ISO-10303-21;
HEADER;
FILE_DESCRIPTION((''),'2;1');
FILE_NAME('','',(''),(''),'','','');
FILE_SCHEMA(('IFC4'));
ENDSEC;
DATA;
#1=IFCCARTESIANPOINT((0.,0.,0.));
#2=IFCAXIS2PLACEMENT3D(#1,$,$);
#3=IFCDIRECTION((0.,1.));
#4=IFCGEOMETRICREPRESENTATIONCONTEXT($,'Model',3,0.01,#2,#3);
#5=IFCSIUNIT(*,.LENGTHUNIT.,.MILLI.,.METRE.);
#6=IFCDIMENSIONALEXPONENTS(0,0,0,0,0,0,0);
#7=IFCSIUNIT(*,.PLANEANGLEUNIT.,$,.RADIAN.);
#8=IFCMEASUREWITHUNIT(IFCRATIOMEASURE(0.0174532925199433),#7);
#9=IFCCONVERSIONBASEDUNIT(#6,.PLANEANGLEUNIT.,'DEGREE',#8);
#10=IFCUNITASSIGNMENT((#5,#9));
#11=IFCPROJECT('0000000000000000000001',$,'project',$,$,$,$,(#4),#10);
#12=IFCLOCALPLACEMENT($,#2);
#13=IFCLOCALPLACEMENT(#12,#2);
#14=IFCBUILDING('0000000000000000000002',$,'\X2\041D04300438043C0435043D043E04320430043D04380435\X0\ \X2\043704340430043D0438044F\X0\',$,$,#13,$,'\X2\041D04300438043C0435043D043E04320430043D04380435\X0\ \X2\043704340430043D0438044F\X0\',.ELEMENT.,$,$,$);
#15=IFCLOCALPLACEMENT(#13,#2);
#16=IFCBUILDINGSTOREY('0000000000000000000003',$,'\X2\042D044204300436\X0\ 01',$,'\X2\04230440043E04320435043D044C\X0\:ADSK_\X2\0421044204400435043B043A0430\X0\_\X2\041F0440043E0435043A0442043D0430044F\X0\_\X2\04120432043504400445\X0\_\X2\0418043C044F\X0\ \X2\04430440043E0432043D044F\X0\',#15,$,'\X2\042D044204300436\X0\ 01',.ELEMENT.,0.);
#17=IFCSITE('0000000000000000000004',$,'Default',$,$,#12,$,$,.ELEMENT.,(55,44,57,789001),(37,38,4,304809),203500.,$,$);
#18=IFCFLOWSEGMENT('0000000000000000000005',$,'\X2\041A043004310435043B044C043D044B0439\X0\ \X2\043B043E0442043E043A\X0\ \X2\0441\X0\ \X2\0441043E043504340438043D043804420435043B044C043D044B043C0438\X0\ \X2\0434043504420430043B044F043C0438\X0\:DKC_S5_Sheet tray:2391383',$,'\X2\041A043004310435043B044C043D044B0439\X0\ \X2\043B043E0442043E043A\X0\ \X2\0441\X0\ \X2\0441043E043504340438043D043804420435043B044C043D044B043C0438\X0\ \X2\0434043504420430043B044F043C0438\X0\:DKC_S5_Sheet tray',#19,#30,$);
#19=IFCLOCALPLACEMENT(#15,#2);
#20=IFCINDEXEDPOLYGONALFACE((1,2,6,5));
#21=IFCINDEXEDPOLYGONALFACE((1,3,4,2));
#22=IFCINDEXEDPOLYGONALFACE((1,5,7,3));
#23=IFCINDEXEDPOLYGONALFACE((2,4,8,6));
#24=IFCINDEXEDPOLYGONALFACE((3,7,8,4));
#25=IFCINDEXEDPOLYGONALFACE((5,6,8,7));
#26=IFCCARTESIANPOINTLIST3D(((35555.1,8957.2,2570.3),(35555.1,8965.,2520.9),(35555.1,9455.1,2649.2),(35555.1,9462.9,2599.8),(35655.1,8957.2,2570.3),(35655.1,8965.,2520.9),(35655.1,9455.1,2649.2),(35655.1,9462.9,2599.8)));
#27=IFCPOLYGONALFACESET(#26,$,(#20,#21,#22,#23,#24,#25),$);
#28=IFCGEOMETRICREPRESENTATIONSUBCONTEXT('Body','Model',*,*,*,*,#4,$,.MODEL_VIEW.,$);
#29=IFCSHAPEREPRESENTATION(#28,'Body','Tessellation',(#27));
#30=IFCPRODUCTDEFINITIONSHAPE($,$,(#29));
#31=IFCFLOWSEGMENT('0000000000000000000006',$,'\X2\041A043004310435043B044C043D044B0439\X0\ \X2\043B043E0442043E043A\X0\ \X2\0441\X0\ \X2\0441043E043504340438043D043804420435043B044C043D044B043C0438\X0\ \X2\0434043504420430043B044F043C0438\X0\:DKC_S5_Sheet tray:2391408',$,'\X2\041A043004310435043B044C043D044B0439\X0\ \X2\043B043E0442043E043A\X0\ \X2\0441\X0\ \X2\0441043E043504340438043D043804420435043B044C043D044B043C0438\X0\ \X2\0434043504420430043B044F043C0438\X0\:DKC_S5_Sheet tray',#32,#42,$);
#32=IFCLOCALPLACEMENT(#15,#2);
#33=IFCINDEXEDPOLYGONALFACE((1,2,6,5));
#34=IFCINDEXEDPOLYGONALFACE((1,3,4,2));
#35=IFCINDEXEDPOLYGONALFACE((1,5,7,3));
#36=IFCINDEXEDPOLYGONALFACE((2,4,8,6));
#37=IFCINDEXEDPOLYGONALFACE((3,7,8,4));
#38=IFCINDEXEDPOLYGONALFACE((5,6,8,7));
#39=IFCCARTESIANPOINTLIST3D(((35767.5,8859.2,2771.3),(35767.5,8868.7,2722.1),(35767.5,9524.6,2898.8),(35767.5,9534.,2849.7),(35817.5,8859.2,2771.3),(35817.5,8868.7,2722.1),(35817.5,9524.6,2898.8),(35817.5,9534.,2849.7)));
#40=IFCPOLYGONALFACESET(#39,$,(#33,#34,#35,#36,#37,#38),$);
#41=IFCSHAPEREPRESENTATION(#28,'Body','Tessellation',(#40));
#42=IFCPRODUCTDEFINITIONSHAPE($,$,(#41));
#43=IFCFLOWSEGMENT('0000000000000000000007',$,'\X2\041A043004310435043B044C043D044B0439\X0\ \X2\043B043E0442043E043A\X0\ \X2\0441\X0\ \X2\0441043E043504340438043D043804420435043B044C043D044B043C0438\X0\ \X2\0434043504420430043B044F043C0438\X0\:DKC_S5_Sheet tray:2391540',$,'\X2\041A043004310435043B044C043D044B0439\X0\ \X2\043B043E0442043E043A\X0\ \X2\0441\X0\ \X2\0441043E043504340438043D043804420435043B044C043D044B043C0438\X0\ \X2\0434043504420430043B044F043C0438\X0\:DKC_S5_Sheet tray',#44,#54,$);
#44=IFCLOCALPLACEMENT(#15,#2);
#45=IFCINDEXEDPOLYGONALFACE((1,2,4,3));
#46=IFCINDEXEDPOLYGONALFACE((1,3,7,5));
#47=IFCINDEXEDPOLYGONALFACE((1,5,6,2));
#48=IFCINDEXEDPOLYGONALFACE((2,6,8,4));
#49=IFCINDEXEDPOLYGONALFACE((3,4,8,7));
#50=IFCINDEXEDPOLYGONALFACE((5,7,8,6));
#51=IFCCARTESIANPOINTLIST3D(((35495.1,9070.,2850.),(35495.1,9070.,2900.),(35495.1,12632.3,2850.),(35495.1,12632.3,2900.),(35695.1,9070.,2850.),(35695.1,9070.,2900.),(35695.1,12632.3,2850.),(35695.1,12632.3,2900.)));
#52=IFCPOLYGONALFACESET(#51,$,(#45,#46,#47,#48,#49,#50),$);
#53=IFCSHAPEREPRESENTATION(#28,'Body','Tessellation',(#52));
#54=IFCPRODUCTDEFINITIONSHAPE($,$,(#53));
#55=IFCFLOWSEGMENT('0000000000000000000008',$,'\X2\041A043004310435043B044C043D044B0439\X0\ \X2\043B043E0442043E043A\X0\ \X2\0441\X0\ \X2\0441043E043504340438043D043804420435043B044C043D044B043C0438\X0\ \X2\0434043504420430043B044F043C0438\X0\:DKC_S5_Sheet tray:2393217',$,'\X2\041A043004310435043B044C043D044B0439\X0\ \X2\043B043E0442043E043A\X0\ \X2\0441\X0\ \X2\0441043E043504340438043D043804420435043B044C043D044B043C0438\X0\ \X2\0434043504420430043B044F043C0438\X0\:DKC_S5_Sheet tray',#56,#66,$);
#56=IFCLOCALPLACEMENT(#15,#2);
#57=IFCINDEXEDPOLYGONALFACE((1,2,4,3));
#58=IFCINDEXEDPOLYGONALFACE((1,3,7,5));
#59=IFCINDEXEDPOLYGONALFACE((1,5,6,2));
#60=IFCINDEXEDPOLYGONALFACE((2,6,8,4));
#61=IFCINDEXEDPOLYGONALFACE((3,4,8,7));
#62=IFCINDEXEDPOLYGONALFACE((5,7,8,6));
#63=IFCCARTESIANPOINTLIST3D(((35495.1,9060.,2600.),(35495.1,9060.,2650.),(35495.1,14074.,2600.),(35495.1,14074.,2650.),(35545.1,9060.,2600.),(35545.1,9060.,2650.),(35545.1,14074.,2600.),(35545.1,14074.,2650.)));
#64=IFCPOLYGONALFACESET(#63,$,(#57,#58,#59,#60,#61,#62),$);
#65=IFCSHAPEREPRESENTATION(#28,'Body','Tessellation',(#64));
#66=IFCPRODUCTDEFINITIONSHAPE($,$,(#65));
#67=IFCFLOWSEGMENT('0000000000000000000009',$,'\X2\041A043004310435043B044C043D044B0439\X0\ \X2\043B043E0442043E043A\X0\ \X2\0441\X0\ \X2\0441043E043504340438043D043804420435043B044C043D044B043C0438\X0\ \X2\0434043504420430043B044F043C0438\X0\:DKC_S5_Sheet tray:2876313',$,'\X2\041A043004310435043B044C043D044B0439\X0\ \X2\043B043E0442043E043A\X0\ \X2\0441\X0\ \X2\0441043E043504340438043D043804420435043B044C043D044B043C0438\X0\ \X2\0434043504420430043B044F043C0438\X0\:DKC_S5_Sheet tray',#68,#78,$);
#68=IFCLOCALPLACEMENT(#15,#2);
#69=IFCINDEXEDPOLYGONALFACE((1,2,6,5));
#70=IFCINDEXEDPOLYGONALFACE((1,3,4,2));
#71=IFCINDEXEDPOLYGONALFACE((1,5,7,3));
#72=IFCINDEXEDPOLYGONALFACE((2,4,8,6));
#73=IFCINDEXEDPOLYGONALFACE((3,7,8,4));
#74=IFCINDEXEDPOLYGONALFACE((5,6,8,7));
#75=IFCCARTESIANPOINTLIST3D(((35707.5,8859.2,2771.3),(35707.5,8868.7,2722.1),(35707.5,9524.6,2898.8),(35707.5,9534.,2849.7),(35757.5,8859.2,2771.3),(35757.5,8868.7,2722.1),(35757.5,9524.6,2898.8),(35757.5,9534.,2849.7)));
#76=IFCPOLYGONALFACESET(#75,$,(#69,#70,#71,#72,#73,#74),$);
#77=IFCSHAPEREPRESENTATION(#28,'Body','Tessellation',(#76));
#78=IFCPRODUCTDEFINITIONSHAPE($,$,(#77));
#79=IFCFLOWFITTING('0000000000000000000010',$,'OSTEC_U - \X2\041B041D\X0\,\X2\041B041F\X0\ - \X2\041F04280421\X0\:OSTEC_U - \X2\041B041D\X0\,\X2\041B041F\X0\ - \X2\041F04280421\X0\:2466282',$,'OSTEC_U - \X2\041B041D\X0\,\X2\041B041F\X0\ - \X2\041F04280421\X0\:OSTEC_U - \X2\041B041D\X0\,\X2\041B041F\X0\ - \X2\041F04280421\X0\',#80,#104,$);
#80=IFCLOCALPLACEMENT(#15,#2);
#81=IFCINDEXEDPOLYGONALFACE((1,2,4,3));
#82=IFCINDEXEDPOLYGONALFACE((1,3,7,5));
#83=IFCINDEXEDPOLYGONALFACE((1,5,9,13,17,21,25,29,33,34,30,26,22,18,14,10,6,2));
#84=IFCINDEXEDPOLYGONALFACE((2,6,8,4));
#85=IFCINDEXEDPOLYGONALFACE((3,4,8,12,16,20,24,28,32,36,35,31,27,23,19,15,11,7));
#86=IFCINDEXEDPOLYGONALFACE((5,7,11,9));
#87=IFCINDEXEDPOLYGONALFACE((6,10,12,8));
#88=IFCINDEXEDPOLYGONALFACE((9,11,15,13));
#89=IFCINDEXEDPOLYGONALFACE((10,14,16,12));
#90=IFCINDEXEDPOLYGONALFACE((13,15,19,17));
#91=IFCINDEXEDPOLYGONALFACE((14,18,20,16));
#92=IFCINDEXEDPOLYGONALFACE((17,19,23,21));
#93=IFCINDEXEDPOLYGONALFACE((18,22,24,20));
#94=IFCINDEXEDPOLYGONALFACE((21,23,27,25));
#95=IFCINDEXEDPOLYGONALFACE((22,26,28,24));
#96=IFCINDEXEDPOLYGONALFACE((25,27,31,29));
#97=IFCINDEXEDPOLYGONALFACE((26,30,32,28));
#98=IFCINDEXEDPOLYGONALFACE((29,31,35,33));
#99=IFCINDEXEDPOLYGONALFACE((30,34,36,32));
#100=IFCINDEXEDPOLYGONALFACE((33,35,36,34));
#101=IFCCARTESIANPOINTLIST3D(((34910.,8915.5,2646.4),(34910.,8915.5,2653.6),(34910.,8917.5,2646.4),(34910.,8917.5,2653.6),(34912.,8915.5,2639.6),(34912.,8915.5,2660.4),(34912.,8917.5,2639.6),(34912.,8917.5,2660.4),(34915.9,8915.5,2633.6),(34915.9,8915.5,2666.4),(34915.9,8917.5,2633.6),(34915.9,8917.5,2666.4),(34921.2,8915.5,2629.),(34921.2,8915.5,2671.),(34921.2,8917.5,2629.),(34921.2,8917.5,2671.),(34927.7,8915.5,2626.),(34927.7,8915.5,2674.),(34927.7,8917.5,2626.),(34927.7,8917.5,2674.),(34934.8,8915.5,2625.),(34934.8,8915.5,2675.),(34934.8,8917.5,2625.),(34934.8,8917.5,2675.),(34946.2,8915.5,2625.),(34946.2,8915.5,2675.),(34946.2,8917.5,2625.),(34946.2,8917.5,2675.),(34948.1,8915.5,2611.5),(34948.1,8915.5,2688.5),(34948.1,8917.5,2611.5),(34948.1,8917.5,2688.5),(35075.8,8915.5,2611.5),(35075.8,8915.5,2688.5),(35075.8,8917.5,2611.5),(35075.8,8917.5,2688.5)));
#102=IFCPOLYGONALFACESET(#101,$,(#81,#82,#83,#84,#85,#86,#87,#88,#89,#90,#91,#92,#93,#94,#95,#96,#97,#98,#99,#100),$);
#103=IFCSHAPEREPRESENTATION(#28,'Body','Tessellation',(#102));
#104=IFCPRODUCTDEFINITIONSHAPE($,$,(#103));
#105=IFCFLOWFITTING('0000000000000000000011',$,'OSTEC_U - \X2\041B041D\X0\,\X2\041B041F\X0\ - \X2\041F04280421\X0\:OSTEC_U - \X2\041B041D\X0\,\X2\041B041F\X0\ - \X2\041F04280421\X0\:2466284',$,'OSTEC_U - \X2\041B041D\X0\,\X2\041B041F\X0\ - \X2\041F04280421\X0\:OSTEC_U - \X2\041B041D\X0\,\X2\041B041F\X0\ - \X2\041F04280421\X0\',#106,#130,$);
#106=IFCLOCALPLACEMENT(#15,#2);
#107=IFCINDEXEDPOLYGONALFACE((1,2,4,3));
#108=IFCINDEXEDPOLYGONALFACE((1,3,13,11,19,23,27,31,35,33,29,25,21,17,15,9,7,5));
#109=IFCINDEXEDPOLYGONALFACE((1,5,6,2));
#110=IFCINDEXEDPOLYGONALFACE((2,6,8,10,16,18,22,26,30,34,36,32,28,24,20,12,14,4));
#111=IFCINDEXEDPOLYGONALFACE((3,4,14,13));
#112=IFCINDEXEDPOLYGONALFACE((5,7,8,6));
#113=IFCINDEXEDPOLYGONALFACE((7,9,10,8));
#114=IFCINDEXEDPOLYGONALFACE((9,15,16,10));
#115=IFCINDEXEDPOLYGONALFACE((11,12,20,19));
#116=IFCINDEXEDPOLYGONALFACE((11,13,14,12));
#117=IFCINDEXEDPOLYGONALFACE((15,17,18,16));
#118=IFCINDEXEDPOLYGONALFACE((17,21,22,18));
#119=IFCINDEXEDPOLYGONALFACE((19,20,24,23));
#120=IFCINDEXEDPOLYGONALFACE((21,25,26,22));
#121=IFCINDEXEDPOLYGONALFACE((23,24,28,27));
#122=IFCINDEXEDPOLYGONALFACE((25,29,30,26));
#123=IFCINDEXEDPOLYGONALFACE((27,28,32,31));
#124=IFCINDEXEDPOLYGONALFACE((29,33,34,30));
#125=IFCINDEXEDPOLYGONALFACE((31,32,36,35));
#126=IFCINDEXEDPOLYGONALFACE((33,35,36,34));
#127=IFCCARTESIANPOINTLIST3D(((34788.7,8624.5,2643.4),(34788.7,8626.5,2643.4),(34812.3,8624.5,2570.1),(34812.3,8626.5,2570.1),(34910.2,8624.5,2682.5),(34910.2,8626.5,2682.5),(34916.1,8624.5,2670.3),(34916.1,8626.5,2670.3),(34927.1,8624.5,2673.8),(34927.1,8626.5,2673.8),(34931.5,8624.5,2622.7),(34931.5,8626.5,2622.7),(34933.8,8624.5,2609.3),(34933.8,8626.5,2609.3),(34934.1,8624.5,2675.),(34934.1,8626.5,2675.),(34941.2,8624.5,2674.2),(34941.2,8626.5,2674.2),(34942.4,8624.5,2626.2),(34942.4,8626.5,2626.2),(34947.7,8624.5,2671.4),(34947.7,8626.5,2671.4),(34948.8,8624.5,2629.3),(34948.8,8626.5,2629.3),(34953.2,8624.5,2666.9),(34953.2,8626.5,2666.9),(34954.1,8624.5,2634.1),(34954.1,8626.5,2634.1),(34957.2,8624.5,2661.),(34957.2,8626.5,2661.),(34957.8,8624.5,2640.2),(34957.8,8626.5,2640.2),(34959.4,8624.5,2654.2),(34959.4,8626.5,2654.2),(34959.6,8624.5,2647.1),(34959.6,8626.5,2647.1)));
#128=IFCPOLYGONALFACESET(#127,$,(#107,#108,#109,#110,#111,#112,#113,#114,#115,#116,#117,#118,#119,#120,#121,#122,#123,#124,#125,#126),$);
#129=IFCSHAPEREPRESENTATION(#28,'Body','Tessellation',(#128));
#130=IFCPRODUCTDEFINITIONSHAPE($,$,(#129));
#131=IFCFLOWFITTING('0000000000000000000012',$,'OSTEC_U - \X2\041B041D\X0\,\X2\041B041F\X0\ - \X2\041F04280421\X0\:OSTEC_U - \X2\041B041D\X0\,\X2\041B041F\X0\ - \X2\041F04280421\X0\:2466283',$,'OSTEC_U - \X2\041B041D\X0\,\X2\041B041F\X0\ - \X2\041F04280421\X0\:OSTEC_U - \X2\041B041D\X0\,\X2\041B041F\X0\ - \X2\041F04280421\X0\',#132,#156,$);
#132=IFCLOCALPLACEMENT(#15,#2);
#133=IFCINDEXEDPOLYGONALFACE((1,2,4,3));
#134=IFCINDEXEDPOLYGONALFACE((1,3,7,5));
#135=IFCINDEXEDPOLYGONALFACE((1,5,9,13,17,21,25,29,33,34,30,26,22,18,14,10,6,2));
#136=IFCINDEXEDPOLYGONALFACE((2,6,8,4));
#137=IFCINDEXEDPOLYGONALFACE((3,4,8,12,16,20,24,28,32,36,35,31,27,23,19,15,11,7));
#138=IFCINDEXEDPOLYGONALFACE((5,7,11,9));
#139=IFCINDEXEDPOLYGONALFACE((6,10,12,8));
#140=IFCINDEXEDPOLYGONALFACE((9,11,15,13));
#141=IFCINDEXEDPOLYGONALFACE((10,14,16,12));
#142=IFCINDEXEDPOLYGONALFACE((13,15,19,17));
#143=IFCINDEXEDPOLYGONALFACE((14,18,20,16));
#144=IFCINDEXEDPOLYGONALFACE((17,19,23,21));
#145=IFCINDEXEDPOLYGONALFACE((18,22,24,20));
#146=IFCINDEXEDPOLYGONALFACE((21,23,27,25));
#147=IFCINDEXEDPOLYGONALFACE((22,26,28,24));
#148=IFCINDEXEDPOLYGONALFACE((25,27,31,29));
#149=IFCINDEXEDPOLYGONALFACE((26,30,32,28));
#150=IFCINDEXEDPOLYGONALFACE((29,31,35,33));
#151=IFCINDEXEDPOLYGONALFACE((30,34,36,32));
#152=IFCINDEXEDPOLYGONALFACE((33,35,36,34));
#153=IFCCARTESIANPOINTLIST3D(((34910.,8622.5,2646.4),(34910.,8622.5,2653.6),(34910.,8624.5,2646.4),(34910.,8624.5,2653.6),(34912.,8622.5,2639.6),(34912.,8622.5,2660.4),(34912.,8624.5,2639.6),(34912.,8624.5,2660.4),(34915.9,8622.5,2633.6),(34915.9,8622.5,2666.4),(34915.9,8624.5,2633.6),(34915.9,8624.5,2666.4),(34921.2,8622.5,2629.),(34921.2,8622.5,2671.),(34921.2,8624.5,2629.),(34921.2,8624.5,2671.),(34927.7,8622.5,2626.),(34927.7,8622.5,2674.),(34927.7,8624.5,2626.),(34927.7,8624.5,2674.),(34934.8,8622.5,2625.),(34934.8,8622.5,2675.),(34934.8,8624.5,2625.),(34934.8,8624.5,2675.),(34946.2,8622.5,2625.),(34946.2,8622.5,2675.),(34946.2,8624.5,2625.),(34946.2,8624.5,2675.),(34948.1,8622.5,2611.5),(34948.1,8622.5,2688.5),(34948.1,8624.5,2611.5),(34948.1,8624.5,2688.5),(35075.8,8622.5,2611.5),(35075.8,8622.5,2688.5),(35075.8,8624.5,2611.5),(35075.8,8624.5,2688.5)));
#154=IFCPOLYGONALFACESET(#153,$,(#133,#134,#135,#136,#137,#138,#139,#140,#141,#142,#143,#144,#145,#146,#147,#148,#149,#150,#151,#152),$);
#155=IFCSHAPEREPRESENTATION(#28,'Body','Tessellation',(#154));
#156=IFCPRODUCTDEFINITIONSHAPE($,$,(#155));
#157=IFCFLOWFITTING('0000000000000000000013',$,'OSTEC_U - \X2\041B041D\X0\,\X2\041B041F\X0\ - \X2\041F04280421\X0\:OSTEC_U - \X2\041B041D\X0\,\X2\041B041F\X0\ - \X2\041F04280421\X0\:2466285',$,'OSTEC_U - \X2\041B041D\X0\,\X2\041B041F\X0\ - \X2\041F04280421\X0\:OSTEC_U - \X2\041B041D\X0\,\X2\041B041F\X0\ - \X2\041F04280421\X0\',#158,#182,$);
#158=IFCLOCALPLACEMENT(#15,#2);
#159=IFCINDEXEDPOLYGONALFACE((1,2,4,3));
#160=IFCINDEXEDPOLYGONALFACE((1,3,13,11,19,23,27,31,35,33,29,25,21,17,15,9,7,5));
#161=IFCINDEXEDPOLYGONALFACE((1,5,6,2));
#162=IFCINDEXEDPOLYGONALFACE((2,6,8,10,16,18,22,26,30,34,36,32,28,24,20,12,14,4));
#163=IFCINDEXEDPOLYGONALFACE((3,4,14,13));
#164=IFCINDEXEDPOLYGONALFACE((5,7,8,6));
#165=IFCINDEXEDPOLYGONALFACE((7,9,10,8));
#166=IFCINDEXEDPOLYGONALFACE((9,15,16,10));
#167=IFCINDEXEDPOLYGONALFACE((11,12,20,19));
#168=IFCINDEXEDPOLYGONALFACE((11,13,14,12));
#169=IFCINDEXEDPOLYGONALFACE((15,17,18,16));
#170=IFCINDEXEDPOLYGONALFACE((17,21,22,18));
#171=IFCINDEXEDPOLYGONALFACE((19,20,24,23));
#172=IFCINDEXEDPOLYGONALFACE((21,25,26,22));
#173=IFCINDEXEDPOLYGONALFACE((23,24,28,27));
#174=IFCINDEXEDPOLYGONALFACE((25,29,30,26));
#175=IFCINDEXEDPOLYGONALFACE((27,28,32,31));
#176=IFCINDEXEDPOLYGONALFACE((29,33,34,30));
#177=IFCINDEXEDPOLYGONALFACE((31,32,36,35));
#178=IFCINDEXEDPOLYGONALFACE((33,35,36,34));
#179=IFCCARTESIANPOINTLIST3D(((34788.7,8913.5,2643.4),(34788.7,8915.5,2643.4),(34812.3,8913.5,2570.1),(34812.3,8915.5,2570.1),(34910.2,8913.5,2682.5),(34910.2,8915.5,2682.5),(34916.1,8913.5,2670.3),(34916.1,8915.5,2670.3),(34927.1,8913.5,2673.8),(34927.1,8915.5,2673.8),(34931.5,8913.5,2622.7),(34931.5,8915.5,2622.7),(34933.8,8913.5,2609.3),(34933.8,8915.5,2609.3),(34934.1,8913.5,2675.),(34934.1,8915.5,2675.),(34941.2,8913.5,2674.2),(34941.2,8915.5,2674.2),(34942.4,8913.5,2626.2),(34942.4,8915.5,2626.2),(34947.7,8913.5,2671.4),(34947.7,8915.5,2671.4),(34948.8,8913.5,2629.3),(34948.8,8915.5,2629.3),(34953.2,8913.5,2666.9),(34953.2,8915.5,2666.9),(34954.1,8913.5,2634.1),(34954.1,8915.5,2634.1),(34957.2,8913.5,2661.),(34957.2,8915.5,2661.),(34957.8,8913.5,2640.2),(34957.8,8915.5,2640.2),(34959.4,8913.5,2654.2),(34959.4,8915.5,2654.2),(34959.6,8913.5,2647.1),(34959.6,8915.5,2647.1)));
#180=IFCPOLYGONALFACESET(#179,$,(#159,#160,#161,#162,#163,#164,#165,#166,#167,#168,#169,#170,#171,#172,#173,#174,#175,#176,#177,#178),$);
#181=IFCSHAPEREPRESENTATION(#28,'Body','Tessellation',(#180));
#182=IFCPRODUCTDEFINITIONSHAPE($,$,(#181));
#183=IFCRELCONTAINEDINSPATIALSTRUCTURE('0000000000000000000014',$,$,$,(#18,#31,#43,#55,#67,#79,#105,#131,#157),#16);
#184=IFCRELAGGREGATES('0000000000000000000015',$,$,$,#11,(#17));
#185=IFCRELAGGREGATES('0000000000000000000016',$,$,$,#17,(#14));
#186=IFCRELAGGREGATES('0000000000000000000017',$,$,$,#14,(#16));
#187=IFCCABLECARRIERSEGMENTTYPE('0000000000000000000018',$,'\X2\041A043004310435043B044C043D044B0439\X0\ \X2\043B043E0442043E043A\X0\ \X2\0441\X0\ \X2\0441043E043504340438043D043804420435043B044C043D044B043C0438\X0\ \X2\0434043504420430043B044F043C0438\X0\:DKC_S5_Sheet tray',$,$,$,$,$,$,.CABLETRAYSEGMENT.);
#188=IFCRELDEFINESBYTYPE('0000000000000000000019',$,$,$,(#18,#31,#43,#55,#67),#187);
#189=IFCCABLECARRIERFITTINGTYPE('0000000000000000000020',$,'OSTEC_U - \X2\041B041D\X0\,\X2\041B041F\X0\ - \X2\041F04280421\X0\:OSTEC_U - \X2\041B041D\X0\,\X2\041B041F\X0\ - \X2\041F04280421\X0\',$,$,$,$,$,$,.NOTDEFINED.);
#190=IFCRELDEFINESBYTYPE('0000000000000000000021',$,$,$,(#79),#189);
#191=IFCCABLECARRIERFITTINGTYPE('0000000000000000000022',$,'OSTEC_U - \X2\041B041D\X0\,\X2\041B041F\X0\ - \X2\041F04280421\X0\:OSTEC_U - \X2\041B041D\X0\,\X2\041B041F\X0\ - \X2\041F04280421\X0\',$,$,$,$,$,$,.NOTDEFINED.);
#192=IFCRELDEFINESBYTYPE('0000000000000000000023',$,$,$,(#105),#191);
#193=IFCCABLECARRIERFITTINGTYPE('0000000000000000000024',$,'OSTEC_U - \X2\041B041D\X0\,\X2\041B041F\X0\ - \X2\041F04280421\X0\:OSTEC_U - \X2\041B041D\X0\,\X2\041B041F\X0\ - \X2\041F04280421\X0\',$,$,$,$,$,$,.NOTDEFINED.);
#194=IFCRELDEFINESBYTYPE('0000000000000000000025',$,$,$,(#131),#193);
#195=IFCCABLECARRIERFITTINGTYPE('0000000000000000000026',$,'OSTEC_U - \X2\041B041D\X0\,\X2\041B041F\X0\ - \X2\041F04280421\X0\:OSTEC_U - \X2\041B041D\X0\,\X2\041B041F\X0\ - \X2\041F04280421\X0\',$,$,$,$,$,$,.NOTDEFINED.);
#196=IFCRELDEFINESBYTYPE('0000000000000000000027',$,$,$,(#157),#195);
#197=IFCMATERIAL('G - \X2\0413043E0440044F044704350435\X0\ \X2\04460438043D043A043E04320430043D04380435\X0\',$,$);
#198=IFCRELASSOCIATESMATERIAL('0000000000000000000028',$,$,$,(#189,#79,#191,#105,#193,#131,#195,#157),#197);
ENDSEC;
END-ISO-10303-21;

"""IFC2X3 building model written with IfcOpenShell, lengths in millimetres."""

from ifc_helpers import new_model, entity, si_unit, converted_unit, direction, frame, frame_2d, origin, origin_2d_with_axis, place, context, subcontext, project, spatial, polyline, circle_curve, parameter, trimmed, segment, composite_curve, rectangle, outline, extrude, source, transform, mapped, material, type_object, type_shapes, element, save


model = new_model("IFC2X3")

# Units and contexts
model_context = context("Model", 3, precision=0.01, world=origin(), true_north=direction((0.0, 1.0)))
body_context = subcontext(model_context, "Body", "Model", "MODEL_VIEW")
ifc_project = project(units=[si_unit("LENGTHUNIT", "METRE", prefix="MILLI"), converted_unit("PLANEANGLEUNIT", "DEGREE", entity("IfcRatioMeasure", 0.0174532925199433), si_unit("PLANEANGLEUNIT", "RADIAN"), dimensions=[0, 0, 0, 0, 0, 0, 0])], contexts=[model_context])

# Site, building, storey
site_placement = place(None, origin())
site = spatial("IfcSite", under=ifc_project, at=site_placement, Name="Default", CompositionType="ELEMENT", RefLatitude=(55, 44, 57, 789001), RefLongitude=(37, 38, 4, 304809), RefElevation=203500.0)
building_placement = place(site_placement, origin())
building = spatial("IfcBuilding", under=site, at=building_placement, Name="Наименование здания", LongName="Наименование здания", CompositionType="ELEMENT")
storey_placement = place(building_placement, origin())
storey = spatial("IfcBuildingStorey", under=building, at=storey_placement, Name="Этаж 01", ObjectType="Уровень:ADSK_Стрелка_Проектная_Вверх_Имя уровня", LongName="Этаж 01", CompositionType="ELEMENT", Elevation=0.0)

# Flow segments
cable_carrier_segment_type = type_object("IfcCableCarrierSegmentType", Name="Кабельный лоток с соединительными деталями:DKC_S5_Sheet tray", PredefinedType="CABLETRAYSEGMENT")
flow_segment_1_placement = place(storey_placement, frame((35555.1, 8957.2, 2520.9)))
element("IfcFlowSegment", 1, at=flow_segment_1_placement, inside=storey, type_object=cable_carrier_segment_type, Name="Кабельный лоток с соединительными деталями:DKC_S5_Sheet tray:2391383", ObjectType="Кабельный лоток с соединительными деталями:DKC_S5_Sheet tray", context=body_context, shape_type="SweptSolid", body=[
    extrude(rectangle(XDim=50.0, YDim=504.1, at=frame_2d((0.0, 0.0), x_axis=(0.0, 1.0))), frame((0.0, 252.8, 64.1), z_axis=(1.0, 0.0, 0.0), x_axis=(0.0, -0.987688, -0.156434)), (0.0, 0.0, 1.0), 100.0),
])
flow_segment_2_placement = place(storey_placement, frame((35767.5, 8859.2, 2722.2)))
element("IfcFlowSegment", 2, at=flow_segment_2_placement, inside=storey, type_object=cable_carrier_segment_type, Name="Кабельный лоток с соединительными деталями:DKC_S5_Sheet tray:2391408", ObjectType="Кабельный лоток с соединительными деталями:DKC_S5_Sheet tray", context=body_context, shape_type="SweptSolid", body=[
    extrude(rectangle(XDim=50.0, YDim=50.0, at=frame_2d((0.0, 0.0), x_axis=(0.0, 1.0))), frame((25.0, 4.7, 24.6), z_axis=(0.0, 0.982106, 0.188332), x_axis=(-1.0, 0.0, 0.0)), (0.0, 0.0, 1.0), 677.5),
])
flow_segment_3_placement = place(storey_placement, frame((35495.1, 9070.0, 2850.0)))
element("IfcFlowSegment", 3, at=flow_segment_3_placement, inside=storey, type_object=cable_carrier_segment_type, Name="Кабельный лоток с соединительными деталями:DKC_S5_Sheet tray:2391540", ObjectType="Кабельный лоток с соединительными деталями:DKC_S5_Sheet tray", context=body_context, shape_type="SweptSolid", body=[
    extrude(rectangle(XDim=3562.3, YDim=200.0, at=origin_2d_with_axis()), frame((100.0, 1781.1, 0.0), z_axis=(0.0, 0.0, 1.0), x_axis=(0.0, 1.0, 0.0)), (0.0, 0.0, 1.0), 50.0),
])
flow_segment_4_placement = place(storey_placement, frame((35495.1, 9060.0, 2600.0)))
element("IfcFlowSegment", 4, at=flow_segment_4_placement, inside=storey, type_object=cable_carrier_segment_type, Name="Кабельный лоток с соединительными деталями:DKC_S5_Sheet tray:2393217", ObjectType="Кабельный лоток с соединительными деталями:DKC_S5_Sheet tray", context=body_context, shape_type="SweptSolid", body=[
    extrude(rectangle(XDim=5014.0, YDim=50.0, at=origin_2d_with_axis()), frame((25.0, 2507.0, 0.0), z_axis=(0.0, 0.0, 1.0), x_axis=(0.0, 1.0, 0.0)), (0.0, 0.0, 1.0), 50.0),
])
flow_segment_5_placement = place(storey_placement, frame((35707.5, 8859.2, 2722.2)))
element("IfcFlowSegment", 5, at=flow_segment_5_placement, inside=storey, type_object=cable_carrier_segment_type, Name="Кабельный лоток с соединительными деталями:DKC_S5_Sheet tray:2876313", ObjectType="Кабельный лоток с соединительными деталями:DKC_S5_Sheet tray", context=body_context, shape_type="SweptSolid", body=[
    extrude(rectangle(XDim=50.0, YDim=50.0, at=frame_2d((0.0, 0.0), x_axis=(0.0, 1.0))), frame((25.0, 4.7, 24.6), z_axis=(0.0, 0.982106, 0.188332), x_axis=(-1.0, 0.0, 0.0)), (0.0, 0.0, 1.0), 677.5),
])

# Flow fittings
ifc_material_1 = material(Name="G - Горячее цинкование")
cable_carrier_fitting_type_1 = type_object("IfcCableCarrierFittingType", Name="OSTEC_U - ЛН,ЛП - ПШС:OSTEC_U - ЛН,ЛП - ПШС", PredefinedType="NOTDEFINED", material=ifc_material_1)
shared_shape_1 = source(origin(), body_context, "Body", "SweptSolid", [
    extrude(outline(composite_curve([segment(trimmed(circle_curve(frame_2d((-41.5, 0.0), x_axis=(1.0, 0.0)), 25.0), [parameter(90.0)], [parameter(270.0)], True, "PARAMETER"), True, "CONTINUOUS"), segment(polyline([(-41.5, -25.0), (-30.0, -25.0)]), True, "CONTINUOUS"), segment(polyline([(-30.0, -25.0), (-28.1, -38.5)]), True, "CONTINUOUS"), segment(polyline([(-28.1, -38.5), (99.5, -38.5)]), True, "CONTINUOUS"), segment(polyline([(99.5, -38.5), (99.5, 38.5)]), True, "CONTINUOUS"), segment(polyline([(99.5, 38.5), (-28.1, 38.5)]), True, "CONTINUOUS"), segment(polyline([(-28.1, 38.5), (-30.0, 25.0)]), True, "CONTINUOUS"), segment(polyline([(-30.0, 25.0), (-41.5, 25.0)]), True, "CONTINUOUS")], self_intersect=False)), frame((41.5, 0.0, 0.0), z_axis=(0.0, 0.0, -1.0), x_axis=(1.0, 0.0, 0.0)), (0.0, 0.0, -1.0), 2.0),
])
type_shapes(cable_carrier_fitting_type_1, [shared_shape_1])
flow_fitting_1_placement = place(storey_placement, frame((34934.8, 8915.5, 2650.0), z_axis=(0.0, 1.0, 0.0), x_axis=(1.0, 0.0, 0.0)))
element("IfcFlowFitting", 6, at=flow_fitting_1_placement, inside=storey, type_object=cable_carrier_fitting_type_1, material=ifc_material_1, Name="OSTEC_U - ЛН,ЛП - ПШС:OSTEC_U - ЛН,ЛП - ПШС:2466282", ObjectType="OSTEC_U - ЛН,ЛП - ПШС:OSTEC_U - ЛН,ЛП - ПШС", context=body_context, shape_type="MappedRepresentation", body=[
    mapped(shared_shape_1, transform((0.0, 0.0, 0.0), scale=1.0)),
])
cable_carrier_fitting_type_2 = type_object("IfcCableCarrierFittingType", Name="OSTEC_U - ЛН,ЛП - ПШС:OSTEC_U - ЛН,ЛП - ПШС", PredefinedType="NOTDEFINED", material=ifc_material_1)
type_shapes(cable_carrier_fitting_type_2, [shared_shape_1])
flow_fitting_2_placement = place(storey_placement, frame((34934.8, 8626.5, 2650.0), z_axis=(0.0, -1.0, 0.0), x_axis=(-0.951851, 0.0, -0.30656)))
element("IfcFlowFitting", 7, at=flow_fitting_2_placement, inside=storey, type_object=cable_carrier_fitting_type_2, material=ifc_material_1, Name="OSTEC_U - ЛН,ЛП - ПШС:OSTEC_U - ЛН,ЛП - ПШС:2466284", ObjectType="OSTEC_U - ЛН,ЛП - ПШС:OSTEC_U - ЛН,ЛП - ПШС", context=body_context, shape_type="MappedRepresentation", body=[
    mapped(shared_shape_1, transform((0.0, 0.0, 0.0), scale=1.0)),
])
cable_carrier_fitting_type_3 = type_object("IfcCableCarrierFittingType", Name="OSTEC_U - ЛН,ЛП - ПШС:OSTEC_U - ЛН,ЛП - ПШС", PredefinedType="NOTDEFINED", material=ifc_material_1)
shared_shape_2 = source(origin(), body_context, "Body", "SweptSolid", [
    extrude(outline(composite_curve([segment(trimmed(circle_curve(frame_2d((-41.5, 0.0), x_axis=(1.0, 0.0)), 25.0), [parameter(90.0)], [parameter(270.0)], True, "PARAMETER"), True, "CONTINUOUS"), segment(polyline([(-41.5, -25.0), (-30.0, -25.0)]), True, "CONTINUOUS"), segment(polyline([(-30.0, -25.0), (-28.1, -38.5)]), True, "CONTINUOUS"), segment(polyline([(-28.1, -38.5), (99.5, -38.5)]), True, "CONTINUOUS"), segment(polyline([(99.5, -38.5), (99.5, 38.5)]), True, "CONTINUOUS"), segment(polyline([(99.5, 38.5), (-28.1, 38.5)]), True, "CONTINUOUS"), segment(polyline([(-28.1, 38.5), (-30.0, 25.0)]), True, "CONTINUOUS"), segment(polyline([(-30.0, 25.0), (-41.5, 25.0)]), True, "CONTINUOUS")], self_intersect=False)), frame((41.5, 0.0, 0.0)), (0.0, 0.0, 1.0), 2.0),
])
type_shapes(cable_carrier_fitting_type_3, [shared_shape_2])
flow_fitting_3_placement = place(storey_placement, frame((34934.8, 8624.5, 2650.0), z_axis=(0.0, -1.0, 0.0), x_axis=(1.0, 0.0, 0.0)))
element("IfcFlowFitting", 8, at=flow_fitting_3_placement, inside=storey, type_object=cable_carrier_fitting_type_3, material=ifc_material_1, Name="OSTEC_U - ЛН,ЛП - ПШС:OSTEC_U - ЛН,ЛП - ПШС:2466283", ObjectType="OSTEC_U - ЛН,ЛП - ПШС:OSTEC_U - ЛН,ЛП - ПШС", context=body_context, shape_type="MappedRepresentation", body=[
    mapped(shared_shape_2, transform((0.0, 0.0, 0.0), scale=1.0)),
])
cable_carrier_fitting_type_4 = type_object("IfcCableCarrierFittingType", Name="OSTEC_U - ЛН,ЛП - ПШС:OSTEC_U - ЛН,ЛП - ПШС", PredefinedType="NOTDEFINED", material=ifc_material_1)
type_shapes(cable_carrier_fitting_type_4, [shared_shape_2])
flow_fitting_4_placement = place(storey_placement, frame((34934.8, 8913.5, 2650.0), z_axis=(0.0, 1.0, 0.0), x_axis=(-0.951851, 0.0, -0.30656)))
element("IfcFlowFitting", 9, at=flow_fitting_4_placement, inside=storey, type_object=cable_carrier_fitting_type_4, material=ifc_material_1, Name="OSTEC_U - ЛН,ЛП - ПШС:OSTEC_U - ЛН,ЛП - ПШС:2466285", ObjectType="OSTEC_U - ЛН,ЛП - ПШС:OSTEC_U - ЛН,ЛП - ПШС", context=body_context, shape_type="MappedRepresentation", body=[
    mapped(shared_shape_2, transform((0.0, 0.0, 0.0), scale=1.0)),
])

save(model, "model.ifc")
